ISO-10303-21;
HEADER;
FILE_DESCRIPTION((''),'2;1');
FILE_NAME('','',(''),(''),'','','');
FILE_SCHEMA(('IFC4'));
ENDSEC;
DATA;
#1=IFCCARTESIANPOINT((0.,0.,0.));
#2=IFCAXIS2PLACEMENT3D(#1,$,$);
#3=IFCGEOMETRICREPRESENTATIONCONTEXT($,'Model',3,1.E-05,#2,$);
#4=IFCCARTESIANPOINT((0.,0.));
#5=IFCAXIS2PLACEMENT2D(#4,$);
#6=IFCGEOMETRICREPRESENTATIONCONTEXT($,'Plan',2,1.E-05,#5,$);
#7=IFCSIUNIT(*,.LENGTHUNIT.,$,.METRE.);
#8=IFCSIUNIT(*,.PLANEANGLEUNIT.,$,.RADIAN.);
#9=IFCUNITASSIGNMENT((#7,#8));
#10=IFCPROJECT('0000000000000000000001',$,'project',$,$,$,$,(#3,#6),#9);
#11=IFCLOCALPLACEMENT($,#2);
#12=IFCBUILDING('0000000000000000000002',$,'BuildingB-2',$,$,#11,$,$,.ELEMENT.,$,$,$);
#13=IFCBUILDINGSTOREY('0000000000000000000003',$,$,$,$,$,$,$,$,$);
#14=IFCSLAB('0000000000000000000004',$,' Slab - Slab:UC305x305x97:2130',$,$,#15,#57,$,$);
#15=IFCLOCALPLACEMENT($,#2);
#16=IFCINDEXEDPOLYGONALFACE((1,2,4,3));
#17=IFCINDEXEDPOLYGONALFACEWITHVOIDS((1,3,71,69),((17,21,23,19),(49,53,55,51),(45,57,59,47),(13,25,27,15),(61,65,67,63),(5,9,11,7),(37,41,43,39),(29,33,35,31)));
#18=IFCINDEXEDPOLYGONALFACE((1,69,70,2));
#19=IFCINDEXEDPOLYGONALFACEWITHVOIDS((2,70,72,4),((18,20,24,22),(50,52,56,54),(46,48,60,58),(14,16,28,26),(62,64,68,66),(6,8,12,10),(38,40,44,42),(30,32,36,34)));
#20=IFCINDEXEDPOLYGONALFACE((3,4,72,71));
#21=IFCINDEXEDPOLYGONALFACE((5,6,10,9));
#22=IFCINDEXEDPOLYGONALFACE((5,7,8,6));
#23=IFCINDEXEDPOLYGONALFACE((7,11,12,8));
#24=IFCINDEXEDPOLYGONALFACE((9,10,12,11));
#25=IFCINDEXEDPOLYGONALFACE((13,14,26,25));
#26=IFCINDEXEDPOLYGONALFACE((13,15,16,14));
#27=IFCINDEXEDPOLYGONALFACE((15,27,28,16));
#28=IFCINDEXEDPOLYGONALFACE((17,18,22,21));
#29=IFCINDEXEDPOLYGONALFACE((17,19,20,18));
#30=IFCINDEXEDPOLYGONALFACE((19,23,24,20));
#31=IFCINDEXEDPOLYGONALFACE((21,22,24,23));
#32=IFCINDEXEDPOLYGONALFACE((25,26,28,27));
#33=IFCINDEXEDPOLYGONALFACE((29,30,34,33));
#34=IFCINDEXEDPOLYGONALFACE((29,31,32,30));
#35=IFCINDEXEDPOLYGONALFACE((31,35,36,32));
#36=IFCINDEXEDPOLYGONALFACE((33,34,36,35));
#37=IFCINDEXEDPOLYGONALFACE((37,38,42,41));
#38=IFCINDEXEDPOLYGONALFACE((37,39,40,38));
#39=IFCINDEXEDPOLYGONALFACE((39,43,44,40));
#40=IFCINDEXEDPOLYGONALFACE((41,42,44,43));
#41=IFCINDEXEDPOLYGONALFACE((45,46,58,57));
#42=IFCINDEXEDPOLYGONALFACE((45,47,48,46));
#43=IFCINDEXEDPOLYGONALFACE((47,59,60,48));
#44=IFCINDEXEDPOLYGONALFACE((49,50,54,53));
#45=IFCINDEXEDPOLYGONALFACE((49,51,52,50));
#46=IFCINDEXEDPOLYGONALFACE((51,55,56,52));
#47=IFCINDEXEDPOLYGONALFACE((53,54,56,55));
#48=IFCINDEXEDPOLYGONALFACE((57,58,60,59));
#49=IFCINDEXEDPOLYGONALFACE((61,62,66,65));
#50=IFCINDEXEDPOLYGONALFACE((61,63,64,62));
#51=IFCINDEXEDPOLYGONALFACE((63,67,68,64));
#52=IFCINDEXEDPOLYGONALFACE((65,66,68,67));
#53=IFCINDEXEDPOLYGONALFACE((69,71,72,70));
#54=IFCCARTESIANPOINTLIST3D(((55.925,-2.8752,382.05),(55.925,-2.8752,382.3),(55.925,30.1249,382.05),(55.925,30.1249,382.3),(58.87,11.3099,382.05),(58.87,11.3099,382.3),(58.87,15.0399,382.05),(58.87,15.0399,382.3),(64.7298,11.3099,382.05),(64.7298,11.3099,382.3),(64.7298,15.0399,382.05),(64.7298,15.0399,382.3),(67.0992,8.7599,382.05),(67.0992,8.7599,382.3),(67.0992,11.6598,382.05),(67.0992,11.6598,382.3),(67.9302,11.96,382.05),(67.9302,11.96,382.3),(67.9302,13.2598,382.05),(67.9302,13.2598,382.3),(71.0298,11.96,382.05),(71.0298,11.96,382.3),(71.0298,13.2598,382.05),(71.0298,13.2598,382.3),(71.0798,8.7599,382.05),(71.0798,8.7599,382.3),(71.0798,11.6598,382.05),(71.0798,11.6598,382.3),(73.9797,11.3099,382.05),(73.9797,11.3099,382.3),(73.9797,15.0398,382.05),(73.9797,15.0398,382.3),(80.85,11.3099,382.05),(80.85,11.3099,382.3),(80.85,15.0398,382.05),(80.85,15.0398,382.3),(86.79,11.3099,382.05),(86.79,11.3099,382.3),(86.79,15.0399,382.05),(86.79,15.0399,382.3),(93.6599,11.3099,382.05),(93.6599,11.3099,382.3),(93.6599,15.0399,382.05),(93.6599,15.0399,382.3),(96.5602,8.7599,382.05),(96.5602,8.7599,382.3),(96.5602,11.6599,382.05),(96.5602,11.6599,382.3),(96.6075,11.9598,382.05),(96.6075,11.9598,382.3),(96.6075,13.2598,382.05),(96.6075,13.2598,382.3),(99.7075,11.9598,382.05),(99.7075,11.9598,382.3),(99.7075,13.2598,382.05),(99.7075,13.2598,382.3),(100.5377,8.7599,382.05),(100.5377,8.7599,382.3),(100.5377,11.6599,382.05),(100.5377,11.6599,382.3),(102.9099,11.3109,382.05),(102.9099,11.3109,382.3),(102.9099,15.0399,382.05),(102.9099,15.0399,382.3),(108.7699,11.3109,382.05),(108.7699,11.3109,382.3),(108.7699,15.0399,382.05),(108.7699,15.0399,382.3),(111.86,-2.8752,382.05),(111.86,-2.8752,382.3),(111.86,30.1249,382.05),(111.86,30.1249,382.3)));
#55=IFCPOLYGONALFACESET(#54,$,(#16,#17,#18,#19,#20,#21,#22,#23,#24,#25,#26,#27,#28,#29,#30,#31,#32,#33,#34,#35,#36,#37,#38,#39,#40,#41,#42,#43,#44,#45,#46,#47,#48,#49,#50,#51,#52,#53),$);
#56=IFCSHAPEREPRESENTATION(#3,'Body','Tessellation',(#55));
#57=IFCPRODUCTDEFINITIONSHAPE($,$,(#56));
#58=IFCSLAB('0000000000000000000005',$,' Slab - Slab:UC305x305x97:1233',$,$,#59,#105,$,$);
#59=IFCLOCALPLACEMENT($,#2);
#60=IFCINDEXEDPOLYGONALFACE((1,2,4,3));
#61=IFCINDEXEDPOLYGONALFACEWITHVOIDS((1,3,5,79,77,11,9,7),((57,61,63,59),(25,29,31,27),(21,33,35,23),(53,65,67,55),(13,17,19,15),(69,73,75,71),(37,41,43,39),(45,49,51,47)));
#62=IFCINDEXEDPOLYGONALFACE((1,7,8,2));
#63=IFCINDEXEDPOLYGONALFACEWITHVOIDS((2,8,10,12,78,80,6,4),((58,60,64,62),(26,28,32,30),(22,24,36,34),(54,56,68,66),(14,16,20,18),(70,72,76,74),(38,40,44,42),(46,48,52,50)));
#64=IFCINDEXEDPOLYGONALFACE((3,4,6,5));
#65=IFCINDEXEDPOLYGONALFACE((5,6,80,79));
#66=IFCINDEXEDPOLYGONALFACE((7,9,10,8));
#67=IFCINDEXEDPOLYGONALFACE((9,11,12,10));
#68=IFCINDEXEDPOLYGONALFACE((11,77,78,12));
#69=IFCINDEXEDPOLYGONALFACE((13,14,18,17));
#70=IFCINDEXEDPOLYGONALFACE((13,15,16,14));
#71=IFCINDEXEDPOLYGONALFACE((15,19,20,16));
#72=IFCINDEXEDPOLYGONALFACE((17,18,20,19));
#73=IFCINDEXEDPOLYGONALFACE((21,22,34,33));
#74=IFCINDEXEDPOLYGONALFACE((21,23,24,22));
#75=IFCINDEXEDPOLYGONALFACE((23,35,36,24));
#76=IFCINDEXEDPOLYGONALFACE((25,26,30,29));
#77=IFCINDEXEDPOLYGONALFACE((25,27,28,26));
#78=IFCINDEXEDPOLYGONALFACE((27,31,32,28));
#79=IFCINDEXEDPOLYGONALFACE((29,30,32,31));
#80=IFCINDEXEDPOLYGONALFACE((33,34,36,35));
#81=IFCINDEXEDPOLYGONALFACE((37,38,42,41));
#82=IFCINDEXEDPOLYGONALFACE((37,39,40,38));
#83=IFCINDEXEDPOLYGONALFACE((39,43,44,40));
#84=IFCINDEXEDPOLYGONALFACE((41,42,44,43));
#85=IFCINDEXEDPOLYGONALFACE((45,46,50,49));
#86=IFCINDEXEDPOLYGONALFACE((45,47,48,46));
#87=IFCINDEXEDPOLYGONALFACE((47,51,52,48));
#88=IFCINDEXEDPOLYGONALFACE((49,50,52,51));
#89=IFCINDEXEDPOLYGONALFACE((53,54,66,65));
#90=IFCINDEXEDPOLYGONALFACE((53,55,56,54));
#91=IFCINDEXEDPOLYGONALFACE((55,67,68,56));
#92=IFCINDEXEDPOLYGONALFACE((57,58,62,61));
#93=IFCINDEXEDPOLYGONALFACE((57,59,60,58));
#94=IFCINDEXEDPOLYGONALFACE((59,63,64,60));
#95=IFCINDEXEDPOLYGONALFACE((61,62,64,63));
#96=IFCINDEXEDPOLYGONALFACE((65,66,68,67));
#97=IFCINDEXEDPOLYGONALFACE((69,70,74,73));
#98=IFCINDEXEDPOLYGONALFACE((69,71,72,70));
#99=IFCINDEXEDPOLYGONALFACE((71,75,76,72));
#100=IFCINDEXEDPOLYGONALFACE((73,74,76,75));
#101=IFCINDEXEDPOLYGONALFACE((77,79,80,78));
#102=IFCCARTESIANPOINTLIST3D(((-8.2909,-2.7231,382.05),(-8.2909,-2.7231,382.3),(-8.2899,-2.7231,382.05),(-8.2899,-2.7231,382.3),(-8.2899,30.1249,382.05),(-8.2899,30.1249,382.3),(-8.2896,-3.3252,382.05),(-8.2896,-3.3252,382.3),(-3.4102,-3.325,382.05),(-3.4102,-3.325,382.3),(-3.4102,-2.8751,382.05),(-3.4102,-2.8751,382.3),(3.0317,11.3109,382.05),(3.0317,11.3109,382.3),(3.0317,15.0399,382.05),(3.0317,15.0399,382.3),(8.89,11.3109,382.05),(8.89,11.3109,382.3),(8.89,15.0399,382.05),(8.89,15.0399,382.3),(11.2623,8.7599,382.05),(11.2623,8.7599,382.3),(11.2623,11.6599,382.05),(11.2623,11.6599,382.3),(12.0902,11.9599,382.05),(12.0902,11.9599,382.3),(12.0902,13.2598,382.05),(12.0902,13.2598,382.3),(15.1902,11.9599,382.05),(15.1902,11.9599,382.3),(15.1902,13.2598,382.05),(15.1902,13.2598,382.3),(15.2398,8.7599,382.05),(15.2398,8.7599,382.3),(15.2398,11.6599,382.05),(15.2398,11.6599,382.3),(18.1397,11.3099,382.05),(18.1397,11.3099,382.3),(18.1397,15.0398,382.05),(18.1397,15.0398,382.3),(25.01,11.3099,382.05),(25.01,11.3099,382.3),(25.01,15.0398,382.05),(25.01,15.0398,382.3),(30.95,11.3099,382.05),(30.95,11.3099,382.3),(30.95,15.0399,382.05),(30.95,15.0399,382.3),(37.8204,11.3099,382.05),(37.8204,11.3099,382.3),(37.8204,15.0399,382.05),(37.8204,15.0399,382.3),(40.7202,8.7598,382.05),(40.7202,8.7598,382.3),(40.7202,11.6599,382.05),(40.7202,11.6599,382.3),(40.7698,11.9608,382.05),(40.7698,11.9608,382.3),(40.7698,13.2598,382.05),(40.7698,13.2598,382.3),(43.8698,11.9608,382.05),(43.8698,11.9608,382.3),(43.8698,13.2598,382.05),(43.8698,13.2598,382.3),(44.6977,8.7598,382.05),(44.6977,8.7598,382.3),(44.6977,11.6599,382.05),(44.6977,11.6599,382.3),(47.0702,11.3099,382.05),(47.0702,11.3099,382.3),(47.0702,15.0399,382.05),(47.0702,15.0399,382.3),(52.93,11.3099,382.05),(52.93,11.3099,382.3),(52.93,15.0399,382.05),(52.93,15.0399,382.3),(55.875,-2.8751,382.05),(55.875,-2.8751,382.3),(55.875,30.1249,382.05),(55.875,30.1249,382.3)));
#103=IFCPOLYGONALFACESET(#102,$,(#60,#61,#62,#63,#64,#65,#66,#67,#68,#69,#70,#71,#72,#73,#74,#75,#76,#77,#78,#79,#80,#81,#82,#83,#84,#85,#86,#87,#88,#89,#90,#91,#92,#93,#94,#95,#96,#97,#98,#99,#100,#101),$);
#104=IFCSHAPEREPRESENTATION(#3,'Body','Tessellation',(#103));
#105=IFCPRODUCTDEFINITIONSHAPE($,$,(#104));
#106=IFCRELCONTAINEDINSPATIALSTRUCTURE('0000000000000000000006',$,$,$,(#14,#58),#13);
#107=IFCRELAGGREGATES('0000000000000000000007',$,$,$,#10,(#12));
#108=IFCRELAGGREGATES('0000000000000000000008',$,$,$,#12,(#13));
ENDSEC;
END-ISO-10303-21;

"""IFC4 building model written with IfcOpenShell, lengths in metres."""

from ifc_helpers import new_model, si_unit, origin, origin_2d, place, context, project, spatial, polyline, outline, extrude, element, save


model = new_model("IFC4")

# Units and contexts
model_context = context("Model", 3, precision=1e-05, world=origin())
plan_context = context("Plan", 2, precision=1e-05, world=origin_2d())
ifc_project = project(units=[si_unit("LENGTHUNIT", "METRE"), si_unit("PLANEANGLEUNIT", "RADIAN")], contexts=[model_context, plan_context])

# Building, storey
building_placement = place(None, origin())
building = spatial("IfcBuilding", under=ifc_project, at=building_placement, Name="BuildingB-2", CompositionType="ELEMENT")
storey = spatial("IfcBuildingStorey", under=building)

# Slabs, openings
slab_1 = element("IfcSlab", 1, inside=storey, Name=" Slab - Slab:UC305x305x97:2130", context=model_context, shape_type="SweptSolid", body=[
    extrude(outline(polyline([(111.86, 30.1249, 382.3), (55.925, 30.1249, 382.3), (55.925, -2.8752, 382.3), (111.86, -2.8752, 382.3), (111.86, 30.1249, 382.3)])), None, (0.0, 0.0, -1.0), 0.25),
])
element("IfcOpeningElement", 2, inside=storey, cuts=slab_1, context=model_context, shape_type="SweptSolid", body=[
    extrude(outline(polyline([(67.0992, 8.7599, 382.3), (71.0798, 8.7599, 382.3), (71.0798, 11.6598, 382.3), (67.0992, 11.6598, 382.3), (67.0992, 8.7599, 382.3)])), None, (0.0, 0.0, -1.0), 0.275),
])
element("IfcOpeningElement", 3, inside=storey, cuts=slab_1, context=model_context, shape_type="SweptSolid", body=[
    extrude(outline(polyline([(67.9302, 11.96, 382.3), (71.0298, 11.96, 382.3), (71.0298, 13.2598, 382.3), (67.9302, 13.2598, 382.3), (67.9302, 11.96, 382.3)])), None, (0.0, 0.0, -1.0), 0.275),
])
element("IfcOpeningElement", 4, inside=storey, cuts=slab_1, context=model_context, shape_type="SweptSolid", body=[
    extrude(outline(polyline([(96.5602, 8.7599, 382.3), (100.5377, 8.7599, 382.3), (100.5377, 11.6599, 382.3), (96.5602, 11.6599, 382.3), (96.5602, 8.7599, 382.3)])), None, (0.0, 0.0, -1.0), 0.275),
])
element("IfcOpeningElement", 5, inside=storey, cuts=slab_1, context=model_context, shape_type="SweptSolid", body=[
    extrude(outline(polyline([(96.6075, 11.9598, 382.3), (99.7075, 11.9598, 382.3), (99.7075, 13.2598, 382.3), (96.6075, 13.2598, 382.3), (96.6075, 11.9598, 382.3)])), None, (0.0, 0.0, -1.0), 0.275),
])
element("IfcOpeningElement", 6, inside=storey, cuts=slab_1, context=model_context, shape_type="SweptSolid", body=[
    extrude(outline(polyline([(108.7699, 15.0399, 382.3), (102.9099, 15.0399, 382.3), (102.9099, 11.3109, 382.3), (108.7699, 11.3109, 382.3), (108.7699, 15.0399, 382.3)])), None, (0.0, 0.0, -1.0), 0.275),
])
element("IfcOpeningElement", 7, inside=storey, cuts=slab_1, context=model_context, shape_type="SweptSolid", body=[
    extrude(outline(polyline([(93.6599, 15.0399, 382.3), (86.79, 15.0399, 382.3), (86.79, 11.3099, 382.3), (93.6599, 11.3099, 382.3), (93.6599, 15.0399, 382.3)])), None, (0.0, 0.0, -1.0), 0.275),
])
element("IfcOpeningElement", 8, inside=storey, cuts=slab_1, context=model_context, shape_type="SweptSolid", body=[
    extrude(outline(polyline([(80.85, 15.0398, 382.3), (73.9797, 15.0398, 382.3), (73.9797, 11.3099, 382.3), (80.85, 11.3099, 382.3), (80.85, 15.0398, 382.3)])), None, (0.0, 0.0, -1.0), 0.275),
])
element("IfcOpeningElement", 9, inside=storey, cuts=slab_1, context=model_context, shape_type="SweptSolid", body=[
    extrude(outline(polyline([(58.87, 11.3099, 382.3), (64.7298, 11.3099, 382.3), (64.7298, 15.0399, 382.3), (58.87, 15.0399, 382.3), (58.87, 11.3099, 382.3)])), None, (0.0, 0.0, -1.0), 0.275),
])
slab_2 = element("IfcSlab", 10, inside=storey, Name=" Slab - Slab:UC305x305x97:1233", context=model_context, shape_type="SweptSolid", body=[
    extrude(outline(polyline([(55.875, 30.1249, 382.3), (55.875, -2.8751, 382.3), (-3.4102, -2.8751, 382.3), (-3.4102, -3.325, 382.3), (-8.2896, -3.3252, 382.3), (-8.2909, -2.7231, 382.3), (-8.2899, -2.7231, 382.3), (-8.2899, 30.1249, 382.3), (55.875, 30.1249, 382.3)])), None, (0.0, 0.0, -1.0), 0.25),
])
element("IfcOpeningElement", 11, inside=storey, cuts=slab_2, context=model_context, shape_type="SweptSolid", body=[
    extrude(outline(polyline([(12.0902, 11.9599, 382.3), (15.1902, 11.9599, 382.3), (15.1902, 13.2598, 382.3), (12.0902, 13.2598, 382.3), (12.0902, 11.9599, 382.3)])), None, (0.0, 0.0, -1.0), 0.275),
])
element("IfcOpeningElement", 12, inside=storey, cuts=slab_2, context=model_context, shape_type="SweptSolid", body=[
    extrude(outline(polyline([(11.2623, 11.6599, 382.3), (15.2398, 11.6599, 382.3), (15.2398, 8.7599, 382.3), (11.2623, 8.7599, 382.3), (11.2623, 11.6599, 382.3)])), None, (0.0, 0.0, -1.0), 0.275),
])
element("IfcOpeningElement", 13, inside=storey, cuts=slab_2, context=model_context, shape_type="SweptSolid", body=[
    extrude(outline(polyline([(40.7698, 11.9608, 382.3), (43.8698, 11.9608, 382.3), (43.8698, 13.2598, 382.3), (40.7698, 13.2598, 382.3), (40.7698, 11.9608, 382.3)])), None, (0.0, 0.0, -1.0), 0.275),
])
element("IfcOpeningElement", 14, inside=storey, cuts=slab_2, context=model_context, shape_type="SweptSolid", body=[
    extrude(outline(polyline([(40.7202, 8.7598, 382.3), (44.6977, 8.7598, 382.3), (44.6977, 11.6599, 382.3), (40.7202, 11.6599, 382.3), (40.7202, 8.7598, 382.3)])), None, (0.0, 0.0, -1.0), 0.275),
])
element("IfcOpeningElement", 15, inside=storey, cuts=slab_2, context=model_context, shape_type="SweptSolid", body=[
    extrude(outline(polyline([(3.0317, 11.3109, 382.3), (8.89, 11.3109, 382.3), (8.89, 15.0399, 382.3), (3.0317, 15.0399, 382.3), (3.0317, 11.3109, 382.3)])), None, (0.0, 0.0, -1.0), 0.275),
])
element("IfcOpeningElement", 16, inside=storey, cuts=slab_2, context=model_context, shape_type="SweptSolid", body=[
    extrude(outline(polyline([(18.1397, 11.3099, 382.3), (25.01, 11.3099, 382.3), (25.01, 15.0398, 382.3), (18.1397, 15.0398, 382.3), (18.1397, 11.3099, 382.3)])), None, (0.0, 0.0, -1.0), 0.275),
])
element("IfcOpeningElement", 17, inside=storey, cuts=slab_2, context=model_context, shape_type="SweptSolid", body=[
    extrude(outline(polyline([(30.95, 11.3099, 382.3), (37.8204, 11.3099, 382.3), (37.8204, 15.0399, 382.3), (30.95, 15.0399, 382.3), (30.95, 11.3099, 382.3)])), None, (0.0, 0.0, -1.0), 0.275),
])
element("IfcOpeningElement", 18, inside=storey, cuts=slab_2, context=model_context, shape_type="SweptSolid", body=[
    extrude(outline(polyline([(47.0702, 11.3099, 382.3), (52.93, 11.3099, 382.3), (52.93, 15.0399, 382.3), (47.0702, 15.0399, 382.3), (47.0702, 11.3099, 382.3)])), None, (0.0, 0.0, -1.0), 0.275),
])

save(model, "model.ifc")
